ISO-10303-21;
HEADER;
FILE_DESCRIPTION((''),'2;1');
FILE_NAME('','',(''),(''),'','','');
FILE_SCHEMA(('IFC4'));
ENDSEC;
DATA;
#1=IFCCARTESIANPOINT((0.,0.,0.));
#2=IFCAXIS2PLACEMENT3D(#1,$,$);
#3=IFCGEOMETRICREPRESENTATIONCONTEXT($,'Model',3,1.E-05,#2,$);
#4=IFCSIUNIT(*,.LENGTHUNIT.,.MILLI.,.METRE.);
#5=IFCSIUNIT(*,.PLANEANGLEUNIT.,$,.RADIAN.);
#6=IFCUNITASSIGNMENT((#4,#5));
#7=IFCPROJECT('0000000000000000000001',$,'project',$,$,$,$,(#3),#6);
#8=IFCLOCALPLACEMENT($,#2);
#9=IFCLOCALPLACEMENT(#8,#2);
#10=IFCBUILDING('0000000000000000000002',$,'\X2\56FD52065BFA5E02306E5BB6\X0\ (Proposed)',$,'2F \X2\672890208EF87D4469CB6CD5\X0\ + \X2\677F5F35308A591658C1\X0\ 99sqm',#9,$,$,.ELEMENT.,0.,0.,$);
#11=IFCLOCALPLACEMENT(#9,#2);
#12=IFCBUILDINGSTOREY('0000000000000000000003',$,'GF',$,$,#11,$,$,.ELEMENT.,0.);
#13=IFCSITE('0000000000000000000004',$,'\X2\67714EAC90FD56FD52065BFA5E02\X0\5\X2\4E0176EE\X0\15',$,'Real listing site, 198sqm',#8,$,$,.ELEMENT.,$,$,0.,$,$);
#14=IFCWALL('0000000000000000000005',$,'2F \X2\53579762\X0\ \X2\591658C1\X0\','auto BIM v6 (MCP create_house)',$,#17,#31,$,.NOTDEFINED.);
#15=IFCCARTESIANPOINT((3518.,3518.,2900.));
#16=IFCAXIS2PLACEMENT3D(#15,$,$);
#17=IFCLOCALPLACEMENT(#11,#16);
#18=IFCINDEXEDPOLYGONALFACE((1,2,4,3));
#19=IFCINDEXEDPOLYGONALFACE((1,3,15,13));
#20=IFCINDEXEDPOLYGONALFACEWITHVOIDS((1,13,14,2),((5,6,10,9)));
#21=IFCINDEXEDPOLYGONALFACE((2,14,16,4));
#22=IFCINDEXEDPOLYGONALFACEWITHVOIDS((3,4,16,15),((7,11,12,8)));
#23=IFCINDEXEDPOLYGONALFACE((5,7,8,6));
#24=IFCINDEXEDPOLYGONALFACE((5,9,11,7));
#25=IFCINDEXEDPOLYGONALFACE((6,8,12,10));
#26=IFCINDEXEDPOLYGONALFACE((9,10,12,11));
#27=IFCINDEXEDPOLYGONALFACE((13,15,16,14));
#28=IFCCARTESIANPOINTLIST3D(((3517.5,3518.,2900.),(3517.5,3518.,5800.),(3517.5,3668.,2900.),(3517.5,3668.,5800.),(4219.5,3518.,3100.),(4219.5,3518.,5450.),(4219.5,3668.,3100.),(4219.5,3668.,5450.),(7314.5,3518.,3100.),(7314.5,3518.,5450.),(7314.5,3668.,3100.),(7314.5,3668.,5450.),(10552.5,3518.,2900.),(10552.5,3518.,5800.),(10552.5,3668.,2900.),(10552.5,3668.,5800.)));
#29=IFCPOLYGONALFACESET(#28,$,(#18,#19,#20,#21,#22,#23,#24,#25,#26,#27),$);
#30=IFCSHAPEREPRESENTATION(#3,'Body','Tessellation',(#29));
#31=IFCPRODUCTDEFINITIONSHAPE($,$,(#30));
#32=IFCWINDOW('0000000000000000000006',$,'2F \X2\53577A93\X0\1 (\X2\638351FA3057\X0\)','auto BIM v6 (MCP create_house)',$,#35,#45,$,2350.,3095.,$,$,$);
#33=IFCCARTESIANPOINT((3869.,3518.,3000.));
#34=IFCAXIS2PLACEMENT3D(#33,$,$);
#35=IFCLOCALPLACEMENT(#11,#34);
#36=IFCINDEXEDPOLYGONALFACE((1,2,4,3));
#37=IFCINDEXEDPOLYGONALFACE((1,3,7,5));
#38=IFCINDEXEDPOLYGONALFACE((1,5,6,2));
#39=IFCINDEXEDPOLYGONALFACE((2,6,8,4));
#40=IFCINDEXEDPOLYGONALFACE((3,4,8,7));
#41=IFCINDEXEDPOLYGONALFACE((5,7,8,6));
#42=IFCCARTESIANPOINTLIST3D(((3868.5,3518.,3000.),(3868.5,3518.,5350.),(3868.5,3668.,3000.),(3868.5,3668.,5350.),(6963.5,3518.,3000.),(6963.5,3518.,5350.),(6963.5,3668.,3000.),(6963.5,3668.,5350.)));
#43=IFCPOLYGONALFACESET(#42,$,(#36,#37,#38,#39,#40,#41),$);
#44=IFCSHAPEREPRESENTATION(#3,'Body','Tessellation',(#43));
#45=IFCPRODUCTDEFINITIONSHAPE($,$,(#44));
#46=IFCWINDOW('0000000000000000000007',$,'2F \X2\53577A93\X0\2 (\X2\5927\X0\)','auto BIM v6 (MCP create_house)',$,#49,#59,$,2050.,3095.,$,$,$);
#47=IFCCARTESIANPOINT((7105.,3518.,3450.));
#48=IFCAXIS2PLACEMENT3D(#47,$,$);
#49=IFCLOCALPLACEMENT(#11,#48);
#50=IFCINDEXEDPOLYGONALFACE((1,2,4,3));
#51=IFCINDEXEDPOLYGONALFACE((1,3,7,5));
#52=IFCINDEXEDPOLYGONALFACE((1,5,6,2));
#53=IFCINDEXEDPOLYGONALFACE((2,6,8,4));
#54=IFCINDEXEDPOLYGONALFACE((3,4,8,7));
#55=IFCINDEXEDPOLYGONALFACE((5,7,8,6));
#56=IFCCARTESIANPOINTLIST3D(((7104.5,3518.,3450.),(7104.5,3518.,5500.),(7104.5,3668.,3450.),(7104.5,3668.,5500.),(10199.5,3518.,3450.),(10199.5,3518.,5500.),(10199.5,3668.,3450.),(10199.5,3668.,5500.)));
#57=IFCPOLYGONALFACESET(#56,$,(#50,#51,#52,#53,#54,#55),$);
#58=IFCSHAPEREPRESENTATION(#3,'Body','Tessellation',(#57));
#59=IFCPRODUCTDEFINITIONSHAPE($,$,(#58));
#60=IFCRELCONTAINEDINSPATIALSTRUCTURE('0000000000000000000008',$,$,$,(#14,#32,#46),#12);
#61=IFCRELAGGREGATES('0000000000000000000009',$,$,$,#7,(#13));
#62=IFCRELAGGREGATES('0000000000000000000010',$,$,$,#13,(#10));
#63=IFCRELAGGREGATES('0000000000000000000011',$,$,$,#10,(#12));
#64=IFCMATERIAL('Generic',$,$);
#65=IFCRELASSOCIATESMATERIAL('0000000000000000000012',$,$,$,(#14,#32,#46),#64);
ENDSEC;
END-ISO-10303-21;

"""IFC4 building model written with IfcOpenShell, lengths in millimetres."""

from ifc_helpers import new_model, si_unit, frame, frame_2d, origin, place, context, project, spatial, rectangle, extrude, material, element, fill, save


model = new_model("IFC4")

# Units and contexts
model_context = context("Model", 3, precision=1e-05, world=origin())
ifc_project = project(units=[si_unit("LENGTHUNIT", "METRE", prefix="MILLI"), si_unit("PLANEANGLEUNIT", "RADIAN")], contexts=[model_context])

# Site, building, storey
site_placement = place(None, origin())
site = spatial("IfcSite", under=ifc_project, at=site_placement, Name="東京都国分寺市5丁目15", ObjectType="Real listing site, 198sqm", CompositionType="ELEMENT", RefElevation=0.0)
building_placement = place(site_placement, origin())
building = spatial("IfcBuilding", under=site, at=building_placement, Name="国分寺市の家 (Proposed)", ObjectType="2F 木造軸組構法 + 板張り外壁 99sqm", CompositionType="ELEMENT", ElevationOfRefHeight=0.0, ElevationOfTerrain=0.0)
storey_placement = place(building_placement, origin())
storey = spatial("IfcBuildingStorey", under=building, at=storey_placement, Name="GF", CompositionType="ELEMENT", Elevation=0.0)

# Shared definitions
ifc_material = material(Name="Generic")

# Wall, openings, windows
wall_1_placement = place(storey_placement, frame((3518.0, 3518.0, 2900.0)))
wall_1 = element("IfcWall", 1, at=wall_1_placement, inside=storey, material=ifc_material, Name="2F 南面 外壁", Description="auto BIM v6 (MCP create_house)", PredefinedType="NOTDEFINED", context=model_context, shape_type="SweptSolid", body=[
    extrude(rectangle(XDim=7035.0, YDim=150.0, at=frame_2d((3517.0, 75.0))), frame((3518.0, 3518.0, 2900.0)), (0.0, 0.0, 1.0), 2900.0),
])
opening_1_placement = place(storey_placement, frame((3869.0, 3518.0, 3000.0)))
opening_1 = element("IfcOpeningElement", 2, at=opening_1_placement, cuts=wall_1, PredefinedType="NOTDEFINED", context=model_context, shape_type="SweptSolid", body=[
    extrude(rectangle(XDim=3095.0, YDim=150.0, at=frame_2d((1547.0, 75.0))), frame((3869.0, 3518.0, 3000.0)), (0.0, 0.0, 1.0), 2350.0),
])
opening_2_placement = place(storey_placement, frame((7105.0, 3518.0, 3450.0)))
opening_2 = element("IfcOpeningElement", 3, at=opening_2_placement, cuts=wall_1, PredefinedType="NOTDEFINED", context=model_context, shape_type="SweptSolid", body=[
    extrude(rectangle(XDim=3095.0, YDim=150.0, at=frame_2d((1547.0, 75.0))), frame((7105.0, 3518.0, 3450.0)), (0.0, 0.0, 1.0), 2050.0),
])
window_1_placement = place(storey_placement, frame((3869.0, 3518.0, 3000.0)))
window_1 = element("IfcWindow", 4, at=window_1_placement, inside=storey, material=ifc_material, Name="2F 南窓1 (掃出し)", Description="auto BIM v6 (MCP create_house)", OverallHeight=2350.0, OverallWidth=3095.0, context=model_context, shape_type="SweptSolid", body=[
    extrude(rectangle(XDim=3095.0, YDim=150.0, at=frame_2d((1547.0, 75.0))), frame((3869.0, 3518.0, 3000.0)), (0.0, 0.0, 1.0), 2350.0),
])
fill(opening_1, window_1)
window_2_placement = place(storey_placement, frame((7105.0, 3518.0, 3450.0)))
window_2 = element("IfcWindow", 5, at=window_2_placement, inside=storey, material=ifc_material, Name="2F 南窓2 (大)", Description="auto BIM v6 (MCP create_house)", OverallHeight=2050.0, OverallWidth=3095.0, context=model_context, shape_type="SweptSolid", body=[
    extrude(rectangle(XDim=3095.0, YDim=150.0, at=frame_2d((1547.0, 75.0))), frame((7105.0, 3518.0, 3450.0)), (0.0, 0.0, 1.0), 2050.0),
])
fill(opening_2, window_2)

save(model, "model.ifc")
